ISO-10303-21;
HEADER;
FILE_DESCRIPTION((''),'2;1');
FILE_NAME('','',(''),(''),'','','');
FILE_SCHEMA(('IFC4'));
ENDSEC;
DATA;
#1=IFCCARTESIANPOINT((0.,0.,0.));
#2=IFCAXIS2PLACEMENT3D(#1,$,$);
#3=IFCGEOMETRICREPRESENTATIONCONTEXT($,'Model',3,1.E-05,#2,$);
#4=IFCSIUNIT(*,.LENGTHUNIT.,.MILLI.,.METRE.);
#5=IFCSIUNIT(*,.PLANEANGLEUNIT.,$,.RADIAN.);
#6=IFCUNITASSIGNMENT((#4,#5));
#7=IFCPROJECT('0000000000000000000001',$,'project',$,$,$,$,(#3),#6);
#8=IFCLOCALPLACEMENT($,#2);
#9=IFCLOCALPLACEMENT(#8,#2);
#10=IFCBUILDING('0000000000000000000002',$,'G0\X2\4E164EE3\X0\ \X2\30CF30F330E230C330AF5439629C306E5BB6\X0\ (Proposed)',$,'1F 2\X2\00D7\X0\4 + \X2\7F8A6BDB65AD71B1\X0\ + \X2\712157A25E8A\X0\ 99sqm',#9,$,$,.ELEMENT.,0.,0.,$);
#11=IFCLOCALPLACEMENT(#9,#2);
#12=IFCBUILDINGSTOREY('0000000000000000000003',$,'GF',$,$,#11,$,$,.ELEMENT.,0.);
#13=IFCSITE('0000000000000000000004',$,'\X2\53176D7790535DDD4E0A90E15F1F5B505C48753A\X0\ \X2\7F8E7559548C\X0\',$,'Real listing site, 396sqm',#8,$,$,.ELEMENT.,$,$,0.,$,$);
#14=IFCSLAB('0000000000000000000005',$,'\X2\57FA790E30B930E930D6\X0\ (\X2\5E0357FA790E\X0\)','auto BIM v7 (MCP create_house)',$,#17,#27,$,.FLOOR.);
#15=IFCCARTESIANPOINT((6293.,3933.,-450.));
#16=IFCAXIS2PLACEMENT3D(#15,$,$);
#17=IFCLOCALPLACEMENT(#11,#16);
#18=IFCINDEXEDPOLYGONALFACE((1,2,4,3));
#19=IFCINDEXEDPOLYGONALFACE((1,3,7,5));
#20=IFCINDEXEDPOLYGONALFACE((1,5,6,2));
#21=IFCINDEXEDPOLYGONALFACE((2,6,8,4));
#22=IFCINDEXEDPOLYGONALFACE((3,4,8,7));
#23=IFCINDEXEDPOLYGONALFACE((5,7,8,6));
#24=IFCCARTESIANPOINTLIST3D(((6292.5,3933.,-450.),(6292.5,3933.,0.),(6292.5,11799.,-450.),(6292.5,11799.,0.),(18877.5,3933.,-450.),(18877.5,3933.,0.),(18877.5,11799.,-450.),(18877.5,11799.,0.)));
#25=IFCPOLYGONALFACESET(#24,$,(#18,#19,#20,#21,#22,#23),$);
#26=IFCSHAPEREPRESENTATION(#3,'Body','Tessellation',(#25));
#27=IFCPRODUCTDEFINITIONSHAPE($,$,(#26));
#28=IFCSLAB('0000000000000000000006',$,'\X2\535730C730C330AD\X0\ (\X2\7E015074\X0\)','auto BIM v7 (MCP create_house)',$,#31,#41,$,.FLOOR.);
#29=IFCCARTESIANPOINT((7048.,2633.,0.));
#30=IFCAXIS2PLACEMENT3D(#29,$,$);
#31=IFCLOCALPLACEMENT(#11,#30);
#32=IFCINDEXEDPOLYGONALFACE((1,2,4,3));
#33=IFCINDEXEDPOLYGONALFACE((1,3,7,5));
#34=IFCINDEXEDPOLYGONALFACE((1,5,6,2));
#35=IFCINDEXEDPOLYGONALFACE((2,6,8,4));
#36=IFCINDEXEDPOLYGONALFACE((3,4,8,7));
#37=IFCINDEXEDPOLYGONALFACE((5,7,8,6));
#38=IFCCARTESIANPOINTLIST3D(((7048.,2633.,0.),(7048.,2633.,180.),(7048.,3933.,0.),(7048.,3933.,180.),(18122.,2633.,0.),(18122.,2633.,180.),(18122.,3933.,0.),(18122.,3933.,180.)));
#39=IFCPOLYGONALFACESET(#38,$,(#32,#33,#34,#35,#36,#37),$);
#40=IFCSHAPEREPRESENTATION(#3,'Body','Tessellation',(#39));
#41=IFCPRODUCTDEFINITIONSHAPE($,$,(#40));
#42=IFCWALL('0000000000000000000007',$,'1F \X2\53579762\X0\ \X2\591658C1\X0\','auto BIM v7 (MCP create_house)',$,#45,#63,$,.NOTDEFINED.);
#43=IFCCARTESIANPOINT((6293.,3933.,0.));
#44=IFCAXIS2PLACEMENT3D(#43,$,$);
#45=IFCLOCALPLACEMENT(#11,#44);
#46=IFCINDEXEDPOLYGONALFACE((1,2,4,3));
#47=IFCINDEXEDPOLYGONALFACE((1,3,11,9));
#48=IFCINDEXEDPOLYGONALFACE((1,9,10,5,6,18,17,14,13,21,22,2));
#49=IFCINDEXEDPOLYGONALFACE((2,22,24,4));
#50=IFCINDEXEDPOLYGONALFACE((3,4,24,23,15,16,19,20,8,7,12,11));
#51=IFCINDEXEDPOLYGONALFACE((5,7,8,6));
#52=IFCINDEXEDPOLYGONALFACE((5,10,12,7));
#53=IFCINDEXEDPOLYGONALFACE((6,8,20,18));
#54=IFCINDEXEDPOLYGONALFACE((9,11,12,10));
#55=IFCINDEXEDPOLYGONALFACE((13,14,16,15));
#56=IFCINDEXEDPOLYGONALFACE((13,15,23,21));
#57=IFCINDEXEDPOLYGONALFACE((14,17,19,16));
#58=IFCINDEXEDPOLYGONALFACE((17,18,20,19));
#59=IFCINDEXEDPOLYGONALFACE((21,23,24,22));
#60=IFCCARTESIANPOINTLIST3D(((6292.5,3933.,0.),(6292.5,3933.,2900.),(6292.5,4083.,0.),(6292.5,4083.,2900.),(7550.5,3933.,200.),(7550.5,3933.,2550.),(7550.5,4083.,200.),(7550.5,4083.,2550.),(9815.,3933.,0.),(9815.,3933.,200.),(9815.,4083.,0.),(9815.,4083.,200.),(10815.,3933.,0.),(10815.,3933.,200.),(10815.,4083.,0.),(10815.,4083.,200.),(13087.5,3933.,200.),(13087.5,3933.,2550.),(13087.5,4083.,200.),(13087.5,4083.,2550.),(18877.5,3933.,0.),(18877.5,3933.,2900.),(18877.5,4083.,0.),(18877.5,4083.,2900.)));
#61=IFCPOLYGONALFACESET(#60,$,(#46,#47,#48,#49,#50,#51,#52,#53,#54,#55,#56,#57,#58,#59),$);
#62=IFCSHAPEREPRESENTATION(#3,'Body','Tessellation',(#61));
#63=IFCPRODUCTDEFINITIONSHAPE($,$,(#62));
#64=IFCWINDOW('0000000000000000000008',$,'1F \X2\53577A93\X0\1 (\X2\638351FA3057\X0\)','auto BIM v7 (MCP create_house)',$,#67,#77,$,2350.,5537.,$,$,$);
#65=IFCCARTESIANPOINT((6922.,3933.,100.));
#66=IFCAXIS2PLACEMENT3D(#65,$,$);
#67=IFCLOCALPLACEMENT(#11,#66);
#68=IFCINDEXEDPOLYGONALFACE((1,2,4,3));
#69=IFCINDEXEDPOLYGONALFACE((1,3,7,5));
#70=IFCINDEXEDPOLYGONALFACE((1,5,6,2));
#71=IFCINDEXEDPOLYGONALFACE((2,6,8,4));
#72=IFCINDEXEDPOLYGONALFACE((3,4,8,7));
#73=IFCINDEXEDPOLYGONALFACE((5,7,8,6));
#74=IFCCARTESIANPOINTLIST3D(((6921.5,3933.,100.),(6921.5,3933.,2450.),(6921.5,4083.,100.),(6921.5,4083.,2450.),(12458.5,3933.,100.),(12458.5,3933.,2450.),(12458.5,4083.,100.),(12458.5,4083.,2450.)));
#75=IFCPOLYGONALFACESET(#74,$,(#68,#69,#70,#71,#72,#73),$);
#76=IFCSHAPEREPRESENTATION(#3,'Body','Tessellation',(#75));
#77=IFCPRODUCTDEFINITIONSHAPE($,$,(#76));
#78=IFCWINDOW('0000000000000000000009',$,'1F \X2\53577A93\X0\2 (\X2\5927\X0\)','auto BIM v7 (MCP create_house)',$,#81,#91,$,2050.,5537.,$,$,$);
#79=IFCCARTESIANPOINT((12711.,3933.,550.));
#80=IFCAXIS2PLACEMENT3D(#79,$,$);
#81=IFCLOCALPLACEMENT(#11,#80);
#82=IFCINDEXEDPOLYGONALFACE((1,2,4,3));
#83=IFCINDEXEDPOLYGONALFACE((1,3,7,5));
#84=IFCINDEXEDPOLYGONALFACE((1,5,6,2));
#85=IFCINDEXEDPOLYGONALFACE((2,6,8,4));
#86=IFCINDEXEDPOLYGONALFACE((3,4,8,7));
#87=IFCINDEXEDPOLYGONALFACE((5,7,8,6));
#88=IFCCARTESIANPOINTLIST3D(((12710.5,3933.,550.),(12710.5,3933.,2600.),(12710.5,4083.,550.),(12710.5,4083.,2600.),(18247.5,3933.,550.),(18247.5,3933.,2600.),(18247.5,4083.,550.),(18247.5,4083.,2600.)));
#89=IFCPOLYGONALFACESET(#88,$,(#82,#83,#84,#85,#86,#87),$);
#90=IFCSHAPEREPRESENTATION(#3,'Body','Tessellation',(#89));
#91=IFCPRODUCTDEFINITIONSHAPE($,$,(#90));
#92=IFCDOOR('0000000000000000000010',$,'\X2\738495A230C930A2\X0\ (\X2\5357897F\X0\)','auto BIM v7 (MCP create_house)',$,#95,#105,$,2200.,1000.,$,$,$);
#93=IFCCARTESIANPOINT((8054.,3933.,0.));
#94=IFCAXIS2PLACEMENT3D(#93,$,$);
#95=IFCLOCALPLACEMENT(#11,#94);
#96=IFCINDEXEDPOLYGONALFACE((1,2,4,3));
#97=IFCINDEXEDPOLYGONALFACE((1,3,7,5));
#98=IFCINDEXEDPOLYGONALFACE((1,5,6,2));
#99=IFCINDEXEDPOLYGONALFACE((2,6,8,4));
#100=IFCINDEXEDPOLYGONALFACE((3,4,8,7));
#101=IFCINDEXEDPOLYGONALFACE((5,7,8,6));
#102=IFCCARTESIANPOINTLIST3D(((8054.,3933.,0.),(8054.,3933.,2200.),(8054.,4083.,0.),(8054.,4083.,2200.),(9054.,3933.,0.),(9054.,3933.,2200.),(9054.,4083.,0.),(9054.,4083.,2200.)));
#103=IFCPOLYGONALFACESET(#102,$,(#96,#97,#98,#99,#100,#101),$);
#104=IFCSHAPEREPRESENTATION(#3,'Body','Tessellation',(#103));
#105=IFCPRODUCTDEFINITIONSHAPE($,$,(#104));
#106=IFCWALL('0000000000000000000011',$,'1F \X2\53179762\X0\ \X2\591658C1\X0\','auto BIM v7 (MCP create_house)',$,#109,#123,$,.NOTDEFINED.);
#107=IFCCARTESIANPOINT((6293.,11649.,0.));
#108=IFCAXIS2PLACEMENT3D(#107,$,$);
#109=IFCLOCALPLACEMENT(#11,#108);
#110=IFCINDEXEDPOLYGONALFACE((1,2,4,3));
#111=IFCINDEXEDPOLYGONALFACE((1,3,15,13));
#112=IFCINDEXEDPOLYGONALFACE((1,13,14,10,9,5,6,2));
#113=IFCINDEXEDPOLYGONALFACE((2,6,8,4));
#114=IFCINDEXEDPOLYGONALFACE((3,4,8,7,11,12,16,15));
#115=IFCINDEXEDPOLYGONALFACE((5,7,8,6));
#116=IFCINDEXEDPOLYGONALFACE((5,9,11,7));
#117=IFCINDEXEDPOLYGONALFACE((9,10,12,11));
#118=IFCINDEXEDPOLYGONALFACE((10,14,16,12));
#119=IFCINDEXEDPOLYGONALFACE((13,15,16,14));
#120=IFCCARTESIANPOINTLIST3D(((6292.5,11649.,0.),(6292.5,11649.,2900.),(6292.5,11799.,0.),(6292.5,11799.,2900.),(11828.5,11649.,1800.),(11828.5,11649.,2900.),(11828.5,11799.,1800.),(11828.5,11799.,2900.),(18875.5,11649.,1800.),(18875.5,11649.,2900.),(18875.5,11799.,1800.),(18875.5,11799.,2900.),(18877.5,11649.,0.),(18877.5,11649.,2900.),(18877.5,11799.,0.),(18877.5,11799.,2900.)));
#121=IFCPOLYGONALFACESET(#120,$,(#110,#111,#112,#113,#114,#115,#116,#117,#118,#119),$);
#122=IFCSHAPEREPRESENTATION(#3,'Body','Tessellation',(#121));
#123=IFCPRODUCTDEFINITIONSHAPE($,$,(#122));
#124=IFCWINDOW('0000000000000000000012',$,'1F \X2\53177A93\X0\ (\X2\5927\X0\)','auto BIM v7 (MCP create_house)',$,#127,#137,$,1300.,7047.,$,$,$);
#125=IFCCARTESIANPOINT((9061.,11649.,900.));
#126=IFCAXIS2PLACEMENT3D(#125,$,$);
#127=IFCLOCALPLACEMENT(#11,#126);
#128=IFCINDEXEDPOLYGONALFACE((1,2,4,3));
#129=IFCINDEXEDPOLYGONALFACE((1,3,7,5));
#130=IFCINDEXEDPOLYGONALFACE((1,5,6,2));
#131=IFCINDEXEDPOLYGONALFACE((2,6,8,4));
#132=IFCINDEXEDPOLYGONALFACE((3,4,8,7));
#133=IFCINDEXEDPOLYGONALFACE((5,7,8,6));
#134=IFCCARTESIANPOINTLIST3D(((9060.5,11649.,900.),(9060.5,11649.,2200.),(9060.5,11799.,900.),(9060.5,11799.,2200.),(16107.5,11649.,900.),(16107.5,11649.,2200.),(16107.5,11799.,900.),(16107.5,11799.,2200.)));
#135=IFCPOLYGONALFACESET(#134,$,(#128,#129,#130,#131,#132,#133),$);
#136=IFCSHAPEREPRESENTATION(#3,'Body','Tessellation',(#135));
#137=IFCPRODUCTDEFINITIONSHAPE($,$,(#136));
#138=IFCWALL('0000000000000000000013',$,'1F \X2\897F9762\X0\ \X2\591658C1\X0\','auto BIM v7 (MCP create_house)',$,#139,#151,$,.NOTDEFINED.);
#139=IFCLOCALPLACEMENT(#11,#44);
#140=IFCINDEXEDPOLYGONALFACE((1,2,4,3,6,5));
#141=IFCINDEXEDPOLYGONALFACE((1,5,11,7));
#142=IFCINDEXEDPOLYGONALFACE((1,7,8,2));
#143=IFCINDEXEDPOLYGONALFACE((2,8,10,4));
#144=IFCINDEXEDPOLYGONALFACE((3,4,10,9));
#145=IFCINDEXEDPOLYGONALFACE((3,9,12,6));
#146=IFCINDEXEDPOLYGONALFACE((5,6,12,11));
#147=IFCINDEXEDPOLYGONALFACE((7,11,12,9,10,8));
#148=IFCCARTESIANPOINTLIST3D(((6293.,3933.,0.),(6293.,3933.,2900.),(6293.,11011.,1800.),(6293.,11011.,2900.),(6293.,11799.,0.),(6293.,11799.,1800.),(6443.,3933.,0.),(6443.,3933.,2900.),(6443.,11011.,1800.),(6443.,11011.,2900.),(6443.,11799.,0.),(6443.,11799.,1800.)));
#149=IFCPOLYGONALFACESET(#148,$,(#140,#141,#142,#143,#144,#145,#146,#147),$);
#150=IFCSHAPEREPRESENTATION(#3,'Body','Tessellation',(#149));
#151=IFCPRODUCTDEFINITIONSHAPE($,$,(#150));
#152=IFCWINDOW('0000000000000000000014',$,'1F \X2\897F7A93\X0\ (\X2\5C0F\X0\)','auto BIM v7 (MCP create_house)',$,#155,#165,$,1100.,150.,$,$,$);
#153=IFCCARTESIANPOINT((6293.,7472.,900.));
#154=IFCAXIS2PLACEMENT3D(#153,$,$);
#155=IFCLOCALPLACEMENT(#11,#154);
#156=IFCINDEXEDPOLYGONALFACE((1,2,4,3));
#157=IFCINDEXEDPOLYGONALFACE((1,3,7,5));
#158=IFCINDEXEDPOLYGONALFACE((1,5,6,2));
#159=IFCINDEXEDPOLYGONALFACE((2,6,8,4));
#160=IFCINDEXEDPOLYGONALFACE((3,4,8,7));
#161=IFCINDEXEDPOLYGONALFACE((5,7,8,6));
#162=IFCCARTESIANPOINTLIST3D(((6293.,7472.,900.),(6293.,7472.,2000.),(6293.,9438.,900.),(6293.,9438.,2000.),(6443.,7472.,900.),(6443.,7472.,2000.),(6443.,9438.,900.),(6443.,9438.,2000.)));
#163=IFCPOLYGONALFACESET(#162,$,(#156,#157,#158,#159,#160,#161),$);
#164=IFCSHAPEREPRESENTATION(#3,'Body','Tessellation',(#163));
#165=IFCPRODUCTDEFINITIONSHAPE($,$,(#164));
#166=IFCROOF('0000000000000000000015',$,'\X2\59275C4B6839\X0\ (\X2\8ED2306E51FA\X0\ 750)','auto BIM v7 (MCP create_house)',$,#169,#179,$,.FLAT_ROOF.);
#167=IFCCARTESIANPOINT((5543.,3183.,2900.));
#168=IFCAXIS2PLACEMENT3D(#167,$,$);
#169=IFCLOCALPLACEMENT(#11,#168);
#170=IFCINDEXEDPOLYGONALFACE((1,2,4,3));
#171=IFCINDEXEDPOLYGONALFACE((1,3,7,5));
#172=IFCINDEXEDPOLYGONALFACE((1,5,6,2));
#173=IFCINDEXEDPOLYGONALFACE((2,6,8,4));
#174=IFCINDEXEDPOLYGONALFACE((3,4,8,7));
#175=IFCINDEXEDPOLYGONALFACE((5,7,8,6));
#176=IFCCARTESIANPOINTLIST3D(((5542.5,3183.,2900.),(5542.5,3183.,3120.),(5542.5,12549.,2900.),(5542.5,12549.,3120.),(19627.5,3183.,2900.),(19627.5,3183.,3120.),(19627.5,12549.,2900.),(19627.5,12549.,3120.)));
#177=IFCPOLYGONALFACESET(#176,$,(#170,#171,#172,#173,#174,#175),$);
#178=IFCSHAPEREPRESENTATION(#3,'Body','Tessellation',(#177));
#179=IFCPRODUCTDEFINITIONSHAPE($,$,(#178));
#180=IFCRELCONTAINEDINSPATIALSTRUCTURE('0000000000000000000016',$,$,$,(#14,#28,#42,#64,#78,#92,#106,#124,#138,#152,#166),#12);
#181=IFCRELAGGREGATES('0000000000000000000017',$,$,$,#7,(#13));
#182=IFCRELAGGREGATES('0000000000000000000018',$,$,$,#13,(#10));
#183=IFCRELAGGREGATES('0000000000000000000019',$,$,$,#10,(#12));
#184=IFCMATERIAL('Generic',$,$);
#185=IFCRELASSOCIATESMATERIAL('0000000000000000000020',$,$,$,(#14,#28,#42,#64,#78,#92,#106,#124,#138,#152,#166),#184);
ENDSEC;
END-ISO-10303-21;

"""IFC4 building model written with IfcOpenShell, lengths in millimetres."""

from ifc_helpers import new_model, si_unit, frame, frame_2d, origin, place, context, project, spatial, rectangle, extrude, material, element, fill, save


model = new_model("IFC4")

# Units and contexts
model_context = context("Model", 3, precision=1e-05, world=origin())
ifc_project = project(units=[si_unit("LENGTHUNIT", "METRE", prefix="MILLI"), si_unit("PLANEANGLEUNIT", "RADIAN")], contexts=[model_context])

# Site, building, storey
site_placement = place(None, origin())
site = spatial("IfcSite", under=ifc_project, at=site_placement, Name="北海道川上郡弟子屈町 美留和", ObjectType="Real listing site, 396sqm", CompositionType="ELEMENT", RefElevation=0.0)
building_placement = place(site_placement, origin())
building = spatial("IfcBuilding", under=site, at=building_placement, Name="G0世代 ハンモック吹抜の家 (Proposed)", ObjectType="1F 2×4 + 羊毛断熱 + 無垢床 99sqm", CompositionType="ELEMENT", ElevationOfRefHeight=0.0, ElevationOfTerrain=0.0)
storey_placement = place(building_placement, origin())
storey = spatial("IfcBuildingStorey", under=building, at=storey_placement, Name="GF", CompositionType="ELEMENT", Elevation=0.0)

# Slabs
ifc_material = material(Name="Generic")
slab_1_placement = place(storey_placement, frame((6293.0, 3933.0, -450.0)))
element("IfcSlab", 1, at=slab_1_placement, inside=storey, material=ifc_material, Name="基礎スラブ (布基礎)", Description="auto BIM v7 (MCP create_house)", PredefinedType="FLOOR", context=model_context, shape_type="SweptSolid", body=[
    extrude(rectangle(XDim=12585.0, YDim=7866.0, at=frame_2d((6292.0, 3933.0))), frame((6293.0, 3933.0, -450.0)), (0.0, 0.0, 1.0), 450.0),
])
slab_2_placement = place(storey_placement, frame((7048.0, 2633.0, 0.0)))
element("IfcSlab", 2, at=slab_2_placement, inside=storey, material=ifc_material, Name="南デッキ (縁側)", Description="auto BIM v7 (MCP create_house)", PredefinedType="FLOOR", context=model_context, shape_type="SweptSolid", body=[
    extrude(rectangle(XDim=11074.0, YDim=1300.0, at=frame_2d((5537.0, 650.0))), frame((7048.0, 2633.0, 0.0)), (0.0, 0.0, 1.0), 180.0),
])

# Wall, openings, windows, door
wall_1_placement = place(storey_placement, frame((6293.0, 3933.0, 0.0)))
wall_1 = element("IfcWall", 3, at=wall_1_placement, inside=storey, material=ifc_material, Name="1F 南面 外壁", Description="auto BIM v7 (MCP create_house)", PredefinedType="NOTDEFINED", context=model_context, shape_type="SweptSolid", body=[
    extrude(rectangle(XDim=12585.0, YDim=150.0, at=frame_2d((6292.0, 75.0))), frame((6293.0, 3933.0, 0.0)), (0.0, 0.0, 1.0), 2900.0),
])
opening_1_placement = place(storey_placement, frame((6922.0, 3933.0, 100.0)))
opening_1 = element("IfcOpeningElement", 4, at=opening_1_placement, cuts=wall_1, PredefinedType="NOTDEFINED", context=model_context, shape_type="SweptSolid", body=[
    extrude(rectangle(XDim=5537.0, YDim=150.0, at=frame_2d((2768.0, 75.0))), frame((6922.0, 3933.0, 100.0)), (0.0, 0.0, 1.0), 2350.0),
])
opening_2_placement = place(storey_placement, frame((12711.0, 3933.0, 550.0)))
opening_2 = element("IfcOpeningElement", 5, at=opening_2_placement, cuts=wall_1, PredefinedType="NOTDEFINED", context=model_context, shape_type="SweptSolid", body=[
    extrude(rectangle(XDim=5537.0, YDim=150.0, at=frame_2d((2768.0, 75.0))), frame((12711.0, 3933.0, 550.0)), (0.0, 0.0, 1.0), 2050.0),
])
opening_3_placement = place(storey_placement, frame((8054.0, 3933.0, 0.0)))
opening_3 = element("IfcOpeningElement", 6, at=opening_3_placement, cuts=wall_1, PredefinedType="NOTDEFINED", context=model_context, shape_type="SweptSolid", body=[
    extrude(rectangle(XDim=1000.0, YDim=150.0, at=frame_2d((500.0, 75.0))), frame((8054.0, 3933.0, 0.0)), (0.0, 0.0, 1.0), 2200.0),
])
window_1_placement = place(storey_placement, frame((6922.0, 3933.0, 100.0)))
window_1 = element("IfcWindow", 7, at=window_1_placement, inside=storey, material=ifc_material, Name="1F 南窓1 (掃出し)", Description="auto BIM v7 (MCP create_house)", OverallHeight=2350.0, OverallWidth=5537.0, context=model_context, shape_type="SweptSolid", body=[
    extrude(rectangle(XDim=5537.0, YDim=150.0, at=frame_2d((2768.0, 75.0))), frame((6922.0, 3933.0, 100.0)), (0.0, 0.0, 1.0), 2350.0),
])
fill(opening_1, window_1)
window_2_placement = place(storey_placement, frame((12711.0, 3933.0, 550.0)))
window_2 = element("IfcWindow", 8, at=window_2_placement, inside=storey, material=ifc_material, Name="1F 南窓2 (大)", Description="auto BIM v7 (MCP create_house)", OverallHeight=2050.0, OverallWidth=5537.0, context=model_context, shape_type="SweptSolid", body=[
    extrude(rectangle(XDim=5537.0, YDim=150.0, at=frame_2d((2768.0, 75.0))), frame((12711.0, 3933.0, 550.0)), (0.0, 0.0, 1.0), 2050.0),
])
fill(opening_2, window_2)
door_placement = place(storey_placement, frame((8054.0, 3933.0, 0.0)))
door = element("IfcDoor", 9, at=door_placement, inside=storey, material=ifc_material, Name="玄関ドア (南西)", Description="auto BIM v7 (MCP create_house)", OverallHeight=2200.0, OverallWidth=1000.0, context=model_context, shape_type="SweptSolid", body=[
    extrude(rectangle(XDim=1000.0, YDim=150.0, at=frame_2d((500.0, 75.0))), frame((8054.0, 3933.0, 0.0)), (0.0, 0.0, 1.0), 2200.0),
])
fill(opening_3, door)

# Walls, openings, windows
wall_2_placement = place(storey_placement, frame((6293.0, 11649.0, 0.0)))
wall_2 = element("IfcWall", 10, at=wall_2_placement, inside=storey, material=ifc_material, Name="1F 北面 外壁", Description="auto BIM v7 (MCP create_house)", PredefinedType="NOTDEFINED", context=model_context, shape_type="SweptSolid", body=[
    extrude(rectangle(XDim=12585.0, YDim=150.0, at=frame_2d((6292.0, 75.0))), frame((6293.0, 11649.0, 0.0)), (0.0, 0.0, 1.0), 2900.0),
])
opening_4_placement = place(storey_placement, frame((9061.0, 11649.0, 900.0)))
opening_4 = element("IfcOpeningElement", 11, at=opening_4_placement, cuts=wall_2, PredefinedType="NOTDEFINED", context=model_context, shape_type="SweptSolid", body=[
    extrude(rectangle(XDim=7047.0, YDim=150.0, at=frame_2d((3523.0, 75.0))), frame((9061.0, 11649.0, 900.0)), (0.0, 0.0, 1.0), 1300.0),
])
window_3_placement = place(storey_placement, frame((9061.0, 11649.0, 900.0)))
window_3 = element("IfcWindow", 12, at=window_3_placement, inside=storey, material=ifc_material, Name="1F 北窓 (大)", Description="auto BIM v7 (MCP create_house)", OverallHeight=1300.0, OverallWidth=7047.0, context=model_context, shape_type="SweptSolid", body=[
    extrude(rectangle(XDim=7047.0, YDim=150.0, at=frame_2d((3523.0, 75.0))), frame((9061.0, 11649.0, 900.0)), (0.0, 0.0, 1.0), 1300.0),
])
fill(opening_4, window_3)
wall_3_placement = place(storey_placement, frame((6293.0, 3933.0, 0.0)))
wall_3 = element("IfcWall", 13, at=wall_3_placement, inside=storey, material=ifc_material, Name="1F 西面 外壁", Description="auto BIM v7 (MCP create_house)", PredefinedType="NOTDEFINED", context=model_context, shape_type="SweptSolid", body=[
    extrude(rectangle(XDim=150.0, YDim=7866.0, at=frame_2d((75.0, 3933.0))), frame((6293.0, 3933.0, 0.0)), (0.0, 0.0, 1.0), 2900.0),
])
opening_5_placement = place(storey_placement, frame((6293.0, 7472.0, 900.0)))
opening_5 = element("IfcOpeningElement", 14, at=opening_5_placement, cuts=wall_3, PredefinedType="NOTDEFINED", context=model_context, shape_type="SweptSolid", body=[
    extrude(rectangle(XDim=150.0, YDim=1966.0, at=frame_2d((75.0, 983.0))), frame((6293.0, 7472.0, 900.0)), (0.0, 0.0, 1.0), 1100.0),
])
window_4_placement = place(storey_placement, frame((6293.0, 7472.0, 900.0)))
window_4 = element("IfcWindow", 15, at=window_4_placement, inside=storey, material=ifc_material, Name="1F 西窓 (小)", Description="auto BIM v7 (MCP create_house)", OverallHeight=1100.0, OverallWidth=150.0, context=model_context, shape_type="SweptSolid", body=[
    extrude(rectangle(XDim=150.0, YDim=1966.0, at=frame_2d((75.0, 983.0))), frame((6293.0, 7472.0, 900.0)), (0.0, 0.0, 1.0), 1100.0),
])
fill(opening_5, window_4)

# Roof
roof_1_placement = place(storey_placement, frame((5543.0, 3183.0, 2900.0)))
element("IfcRoof", 16, at=roof_1_placement, inside=storey, material=ifc_material, Name="大屋根 (軒の出 750)", Description="auto BIM v7 (MCP create_house)", PredefinedType="FLAT_ROOF", context=model_context, shape_type="SweptSolid", body=[
    extrude(rectangle(XDim=14085.0, YDim=9366.0, at=frame_2d((7042.0, 4683.0))), frame((5543.0, 3183.0, 2900.0)), (0.0, 0.0, 1.0), 220.0),
])

save(model, "model.ifc")
